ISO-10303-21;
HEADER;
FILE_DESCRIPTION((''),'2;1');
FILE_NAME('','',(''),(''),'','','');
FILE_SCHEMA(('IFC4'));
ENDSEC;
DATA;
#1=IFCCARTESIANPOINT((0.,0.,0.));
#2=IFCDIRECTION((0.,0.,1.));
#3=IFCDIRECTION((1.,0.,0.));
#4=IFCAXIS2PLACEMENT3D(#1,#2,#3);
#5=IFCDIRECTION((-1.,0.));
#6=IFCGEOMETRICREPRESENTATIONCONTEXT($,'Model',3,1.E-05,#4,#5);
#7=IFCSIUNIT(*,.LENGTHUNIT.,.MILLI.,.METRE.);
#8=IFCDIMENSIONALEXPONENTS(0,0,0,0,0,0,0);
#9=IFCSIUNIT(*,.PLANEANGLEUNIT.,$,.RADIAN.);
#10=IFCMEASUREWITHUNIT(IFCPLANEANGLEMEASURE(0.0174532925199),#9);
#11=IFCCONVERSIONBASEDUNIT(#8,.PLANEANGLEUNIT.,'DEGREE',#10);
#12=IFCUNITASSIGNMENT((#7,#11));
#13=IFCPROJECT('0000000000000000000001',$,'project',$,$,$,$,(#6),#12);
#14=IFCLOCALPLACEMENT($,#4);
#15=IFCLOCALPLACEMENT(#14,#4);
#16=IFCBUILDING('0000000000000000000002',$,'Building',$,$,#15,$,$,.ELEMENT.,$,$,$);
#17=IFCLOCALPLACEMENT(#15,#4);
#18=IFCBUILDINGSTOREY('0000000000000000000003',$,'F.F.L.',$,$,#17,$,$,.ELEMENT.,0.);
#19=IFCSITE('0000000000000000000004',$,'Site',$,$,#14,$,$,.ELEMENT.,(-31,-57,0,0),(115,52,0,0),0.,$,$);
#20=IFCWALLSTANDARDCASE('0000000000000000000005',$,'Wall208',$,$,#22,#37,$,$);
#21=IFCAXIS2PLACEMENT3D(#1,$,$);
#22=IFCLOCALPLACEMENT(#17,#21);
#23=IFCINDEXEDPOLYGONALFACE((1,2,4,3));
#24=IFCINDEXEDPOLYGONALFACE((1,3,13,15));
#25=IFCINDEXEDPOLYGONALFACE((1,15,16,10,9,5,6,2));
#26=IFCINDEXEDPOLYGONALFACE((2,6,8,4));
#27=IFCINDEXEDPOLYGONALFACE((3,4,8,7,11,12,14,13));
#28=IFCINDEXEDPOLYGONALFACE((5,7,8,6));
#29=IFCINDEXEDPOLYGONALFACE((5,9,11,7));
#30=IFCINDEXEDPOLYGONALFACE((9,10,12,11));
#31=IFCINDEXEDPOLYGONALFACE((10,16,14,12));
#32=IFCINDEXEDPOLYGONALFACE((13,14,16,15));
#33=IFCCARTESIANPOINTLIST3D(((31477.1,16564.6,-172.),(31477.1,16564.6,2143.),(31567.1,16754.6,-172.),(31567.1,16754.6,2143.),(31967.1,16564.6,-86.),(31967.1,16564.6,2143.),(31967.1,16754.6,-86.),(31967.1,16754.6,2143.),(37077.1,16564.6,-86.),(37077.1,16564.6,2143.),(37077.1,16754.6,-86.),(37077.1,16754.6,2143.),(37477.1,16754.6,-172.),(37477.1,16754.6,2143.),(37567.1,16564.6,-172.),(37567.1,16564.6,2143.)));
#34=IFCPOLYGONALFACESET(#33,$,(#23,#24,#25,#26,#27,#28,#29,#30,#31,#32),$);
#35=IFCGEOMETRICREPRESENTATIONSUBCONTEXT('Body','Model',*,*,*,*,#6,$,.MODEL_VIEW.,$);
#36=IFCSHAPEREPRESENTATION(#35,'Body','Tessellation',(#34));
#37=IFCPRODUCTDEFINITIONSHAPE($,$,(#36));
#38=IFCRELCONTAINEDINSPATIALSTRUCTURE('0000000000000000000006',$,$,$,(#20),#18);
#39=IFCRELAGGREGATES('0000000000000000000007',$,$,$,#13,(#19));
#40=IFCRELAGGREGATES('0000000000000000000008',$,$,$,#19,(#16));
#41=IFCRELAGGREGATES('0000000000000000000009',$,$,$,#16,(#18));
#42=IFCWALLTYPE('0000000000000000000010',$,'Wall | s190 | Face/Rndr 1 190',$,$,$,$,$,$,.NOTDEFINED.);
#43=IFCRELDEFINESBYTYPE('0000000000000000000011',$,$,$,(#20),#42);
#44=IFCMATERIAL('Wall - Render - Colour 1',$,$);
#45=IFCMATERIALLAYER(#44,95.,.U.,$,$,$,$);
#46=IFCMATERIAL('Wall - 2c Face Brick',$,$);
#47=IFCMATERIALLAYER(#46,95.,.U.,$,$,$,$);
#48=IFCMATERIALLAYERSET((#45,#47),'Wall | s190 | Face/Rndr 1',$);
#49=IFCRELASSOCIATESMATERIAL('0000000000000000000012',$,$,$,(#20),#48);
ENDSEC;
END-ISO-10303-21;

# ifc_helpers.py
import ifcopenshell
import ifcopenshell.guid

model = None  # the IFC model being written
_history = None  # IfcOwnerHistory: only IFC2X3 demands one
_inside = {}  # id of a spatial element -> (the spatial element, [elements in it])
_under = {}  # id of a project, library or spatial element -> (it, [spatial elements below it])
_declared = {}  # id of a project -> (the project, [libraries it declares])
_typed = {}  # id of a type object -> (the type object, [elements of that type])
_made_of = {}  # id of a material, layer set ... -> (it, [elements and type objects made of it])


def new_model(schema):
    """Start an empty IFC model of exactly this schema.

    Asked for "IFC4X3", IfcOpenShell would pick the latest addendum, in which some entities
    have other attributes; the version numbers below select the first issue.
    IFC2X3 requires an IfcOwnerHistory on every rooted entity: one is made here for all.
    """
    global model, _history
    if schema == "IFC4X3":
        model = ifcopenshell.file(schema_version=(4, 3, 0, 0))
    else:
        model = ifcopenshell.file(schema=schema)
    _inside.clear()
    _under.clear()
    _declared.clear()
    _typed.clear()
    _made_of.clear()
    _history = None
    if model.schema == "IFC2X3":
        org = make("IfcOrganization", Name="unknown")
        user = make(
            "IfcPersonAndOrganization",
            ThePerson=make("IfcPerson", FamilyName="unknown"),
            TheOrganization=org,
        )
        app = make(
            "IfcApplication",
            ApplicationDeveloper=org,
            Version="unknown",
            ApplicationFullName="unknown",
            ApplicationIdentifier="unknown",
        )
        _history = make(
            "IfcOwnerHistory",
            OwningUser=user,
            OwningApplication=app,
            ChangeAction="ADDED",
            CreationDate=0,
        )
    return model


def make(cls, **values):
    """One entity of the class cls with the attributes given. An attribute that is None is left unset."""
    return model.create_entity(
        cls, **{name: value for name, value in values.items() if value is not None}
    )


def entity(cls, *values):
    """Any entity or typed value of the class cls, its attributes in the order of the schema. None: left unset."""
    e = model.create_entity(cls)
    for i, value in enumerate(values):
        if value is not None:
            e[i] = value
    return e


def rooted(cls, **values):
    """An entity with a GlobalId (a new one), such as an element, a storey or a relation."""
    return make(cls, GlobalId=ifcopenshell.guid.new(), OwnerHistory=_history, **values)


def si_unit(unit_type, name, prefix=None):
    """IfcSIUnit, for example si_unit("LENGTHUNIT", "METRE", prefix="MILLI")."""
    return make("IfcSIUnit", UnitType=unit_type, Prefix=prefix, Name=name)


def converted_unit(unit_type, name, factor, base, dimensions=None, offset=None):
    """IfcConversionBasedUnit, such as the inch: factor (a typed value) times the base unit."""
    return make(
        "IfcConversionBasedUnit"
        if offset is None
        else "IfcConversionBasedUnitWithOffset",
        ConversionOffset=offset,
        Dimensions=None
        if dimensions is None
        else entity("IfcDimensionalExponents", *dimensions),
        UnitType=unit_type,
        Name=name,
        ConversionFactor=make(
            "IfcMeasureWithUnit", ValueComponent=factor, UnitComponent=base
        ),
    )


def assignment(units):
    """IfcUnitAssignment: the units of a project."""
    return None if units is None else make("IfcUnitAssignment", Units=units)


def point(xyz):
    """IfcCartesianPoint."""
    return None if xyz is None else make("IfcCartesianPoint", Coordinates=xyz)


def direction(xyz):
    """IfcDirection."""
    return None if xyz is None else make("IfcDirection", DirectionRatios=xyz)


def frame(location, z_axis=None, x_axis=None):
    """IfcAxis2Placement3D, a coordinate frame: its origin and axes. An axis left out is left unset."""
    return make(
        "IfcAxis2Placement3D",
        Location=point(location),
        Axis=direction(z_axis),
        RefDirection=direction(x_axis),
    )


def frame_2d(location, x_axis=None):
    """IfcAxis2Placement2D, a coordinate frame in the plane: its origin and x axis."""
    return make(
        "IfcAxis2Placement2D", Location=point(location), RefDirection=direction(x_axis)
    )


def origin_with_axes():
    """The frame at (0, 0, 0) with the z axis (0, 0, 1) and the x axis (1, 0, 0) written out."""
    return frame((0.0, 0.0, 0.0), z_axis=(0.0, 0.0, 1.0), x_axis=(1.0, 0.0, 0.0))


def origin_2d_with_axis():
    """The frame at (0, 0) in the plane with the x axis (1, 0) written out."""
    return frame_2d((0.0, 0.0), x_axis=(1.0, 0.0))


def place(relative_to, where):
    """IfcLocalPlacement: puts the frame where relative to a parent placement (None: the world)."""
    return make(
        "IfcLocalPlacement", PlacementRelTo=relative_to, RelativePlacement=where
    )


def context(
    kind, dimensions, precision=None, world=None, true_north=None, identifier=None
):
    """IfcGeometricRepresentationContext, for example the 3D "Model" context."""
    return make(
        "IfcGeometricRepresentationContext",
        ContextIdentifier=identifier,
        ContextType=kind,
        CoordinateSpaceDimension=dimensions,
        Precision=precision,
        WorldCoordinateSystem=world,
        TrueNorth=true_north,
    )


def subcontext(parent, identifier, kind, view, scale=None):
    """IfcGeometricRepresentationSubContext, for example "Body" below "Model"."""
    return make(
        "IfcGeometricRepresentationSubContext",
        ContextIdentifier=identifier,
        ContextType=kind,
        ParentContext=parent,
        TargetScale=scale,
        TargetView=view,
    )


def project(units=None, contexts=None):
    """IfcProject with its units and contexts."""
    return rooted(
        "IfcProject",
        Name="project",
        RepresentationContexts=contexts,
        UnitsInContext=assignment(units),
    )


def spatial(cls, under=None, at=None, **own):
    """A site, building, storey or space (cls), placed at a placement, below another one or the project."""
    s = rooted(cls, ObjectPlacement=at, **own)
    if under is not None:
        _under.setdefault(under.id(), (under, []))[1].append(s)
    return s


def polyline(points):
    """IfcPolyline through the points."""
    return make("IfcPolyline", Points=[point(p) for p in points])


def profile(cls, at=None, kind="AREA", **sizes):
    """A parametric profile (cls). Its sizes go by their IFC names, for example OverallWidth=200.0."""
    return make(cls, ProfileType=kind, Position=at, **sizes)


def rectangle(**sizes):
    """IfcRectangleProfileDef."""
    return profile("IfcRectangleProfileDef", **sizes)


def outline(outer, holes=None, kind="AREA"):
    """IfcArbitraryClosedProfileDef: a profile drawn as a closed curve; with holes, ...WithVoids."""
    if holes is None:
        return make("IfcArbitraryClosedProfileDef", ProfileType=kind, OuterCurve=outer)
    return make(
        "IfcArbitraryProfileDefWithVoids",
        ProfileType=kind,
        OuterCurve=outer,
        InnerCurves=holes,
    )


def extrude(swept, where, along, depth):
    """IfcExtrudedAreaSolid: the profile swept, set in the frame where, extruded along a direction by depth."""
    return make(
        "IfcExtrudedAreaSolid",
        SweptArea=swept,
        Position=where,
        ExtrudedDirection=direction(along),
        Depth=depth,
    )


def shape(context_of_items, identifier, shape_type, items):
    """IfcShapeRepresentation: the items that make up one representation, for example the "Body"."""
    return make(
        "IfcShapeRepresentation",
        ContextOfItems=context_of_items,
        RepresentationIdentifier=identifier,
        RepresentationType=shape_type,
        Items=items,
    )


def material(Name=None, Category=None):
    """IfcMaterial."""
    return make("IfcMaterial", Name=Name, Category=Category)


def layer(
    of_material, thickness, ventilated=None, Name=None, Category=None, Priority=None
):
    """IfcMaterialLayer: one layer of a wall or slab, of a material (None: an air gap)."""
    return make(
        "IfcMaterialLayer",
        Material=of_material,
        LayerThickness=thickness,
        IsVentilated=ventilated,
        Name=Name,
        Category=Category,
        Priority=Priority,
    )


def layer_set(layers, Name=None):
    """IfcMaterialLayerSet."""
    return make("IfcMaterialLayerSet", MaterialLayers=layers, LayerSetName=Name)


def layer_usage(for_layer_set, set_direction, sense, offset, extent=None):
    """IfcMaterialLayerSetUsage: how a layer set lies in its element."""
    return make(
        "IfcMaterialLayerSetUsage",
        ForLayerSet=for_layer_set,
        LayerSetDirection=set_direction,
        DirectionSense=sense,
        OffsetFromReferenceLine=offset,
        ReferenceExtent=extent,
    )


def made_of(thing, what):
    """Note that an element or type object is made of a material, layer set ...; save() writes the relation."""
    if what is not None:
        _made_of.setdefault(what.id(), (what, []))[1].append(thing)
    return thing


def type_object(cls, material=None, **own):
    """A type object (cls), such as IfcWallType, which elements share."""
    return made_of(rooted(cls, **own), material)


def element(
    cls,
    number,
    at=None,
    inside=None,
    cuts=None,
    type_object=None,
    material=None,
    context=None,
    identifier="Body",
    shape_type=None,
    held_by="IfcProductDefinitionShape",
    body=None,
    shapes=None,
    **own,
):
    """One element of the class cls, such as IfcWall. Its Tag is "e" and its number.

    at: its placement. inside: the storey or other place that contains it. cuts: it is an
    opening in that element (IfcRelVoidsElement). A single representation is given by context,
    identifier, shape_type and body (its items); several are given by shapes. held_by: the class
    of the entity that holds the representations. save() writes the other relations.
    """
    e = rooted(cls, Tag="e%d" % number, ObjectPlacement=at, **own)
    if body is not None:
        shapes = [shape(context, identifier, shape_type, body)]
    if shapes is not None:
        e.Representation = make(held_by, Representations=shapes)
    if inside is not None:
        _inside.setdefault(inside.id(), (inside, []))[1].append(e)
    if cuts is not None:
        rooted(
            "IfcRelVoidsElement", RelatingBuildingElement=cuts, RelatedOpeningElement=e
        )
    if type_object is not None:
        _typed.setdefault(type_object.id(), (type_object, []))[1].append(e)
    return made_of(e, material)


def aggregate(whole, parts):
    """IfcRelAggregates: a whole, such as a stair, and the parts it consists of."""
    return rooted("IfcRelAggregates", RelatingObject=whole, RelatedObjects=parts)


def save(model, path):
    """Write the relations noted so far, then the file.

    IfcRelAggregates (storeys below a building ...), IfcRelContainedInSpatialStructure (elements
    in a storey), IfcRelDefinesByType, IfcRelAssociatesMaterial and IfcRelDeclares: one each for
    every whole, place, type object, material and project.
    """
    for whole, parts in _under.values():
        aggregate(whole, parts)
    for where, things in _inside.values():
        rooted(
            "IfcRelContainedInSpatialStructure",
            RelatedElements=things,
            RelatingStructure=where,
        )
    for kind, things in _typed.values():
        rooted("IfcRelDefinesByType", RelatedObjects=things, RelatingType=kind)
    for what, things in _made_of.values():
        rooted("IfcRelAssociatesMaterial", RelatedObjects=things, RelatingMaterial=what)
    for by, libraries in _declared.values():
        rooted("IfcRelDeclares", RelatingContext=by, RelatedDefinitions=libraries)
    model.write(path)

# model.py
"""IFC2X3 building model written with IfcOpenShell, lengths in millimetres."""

from ifc_helpers import new_model, entity, si_unit, converted_unit, direction, frame, origin_with_axes, origin_2d_with_axis, place, context, subcontext, project, spatial, polyline, rectangle, outline, extrude, material, layer, layer_set, layer_usage, type_object, element, save


model = new_model("IFC2X3")

# Units and contexts
model_context = context("Model", 3, precision=1e-05, world=origin_with_axes(), true_north=direction((-1.0, 0.0)))
body_context = subcontext(model_context, "Body", "Model", "MODEL_VIEW")
ifc_project = project(units=[si_unit("LENGTHUNIT", "METRE", prefix="MILLI"), converted_unit("PLANEANGLEUNIT", "DEGREE", entity("IfcPlaneAngleMeasure", 0.0174532925199), si_unit("PLANEANGLEUNIT", "RADIAN"), dimensions=[0, 0, 0, 0, 0, 0, 0])], contexts=[model_context])

# Site, building, storey
site_placement = place(None, origin_with_axes())
site = spatial("IfcSite", under=ifc_project, at=site_placement, Name="Site", CompositionType="ELEMENT", RefLatitude=(-31, -57, 0, 0), RefLongitude=(115, 52, 0, 0), RefElevation=0.0)
building_placement = place(site_placement, origin_with_axes())
building = spatial("IfcBuilding", under=site, at=building_placement, Name="Building", CompositionType="ELEMENT")
storey_placement = place(building_placement, origin_with_axes())
storey = spatial("IfcBuildingStorey", under=building, at=storey_placement, Name="F.F.L.", CompositionType="ELEMENT", Elevation=0.0)

# Shared definitions
ifc_material_1 = material(Name="Wall - 2c Face Brick")

# Shared definitions
ifc_material_2 = material(Name="Wall - Render - Colour 1")

# Wall, opening
ifc_layer_1 = layer(ifc_material_2, 95.0, ventilated="UNKNOWN")
ifc_layer_2 = layer(ifc_material_1, 95.0, ventilated="UNKNOWN")
ifc_layer_set_1 = layer_set([ifc_layer_1, ifc_layer_2], Name="Wall | s190 | Face/Rndr 1")
ifc_layer_usage_1 = layer_usage(ifc_layer_set_1, "AXIS2", "NEGATIVE", 0.0)
wall_type_1 = type_object("IfcWallType", Name="Wall | s190 | Face/Rndr 1 190", PredefinedType="NOTDEFINED")
wall_1_placement = place(storey_placement, frame((37567.1, 16564.6, -172.0), z_axis=(0.0, 0.0, 1.0), x_axis=(-1.0, 0.0, 0.0)))
wall_1 = element("IfcWallStandardCase", 1, at=wall_1_placement, inside=storey, type_object=wall_type_1, material=ifc_layer_usage_1, Name="Wall208", context=body_context, shape_type="SweptSolid", body=[
    extrude(outline(polyline([(90.0, -190.0), (6000.0, -190.0), (6090.0, 0.0), (0.0, 0.0), (90.0, -190.0)])), origin_with_axes(), (0.0, 0.0, 1.0), 2315.0),
])
opening_1_placement = place(wall_1_placement, frame((3045.0, 0.0, 86.0), z_axis=(0.0, 0.0, 1.0), x_axis=(1.0, 0.0, 0.0)))
element("IfcOpeningElement", 2, at=opening_1_placement, cuts=wall_1, context=body_context, shape_type="SweptSolid", body=[
    extrude(rectangle(XDim=5110.0, YDim=2229.0, at=origin_2d_with_axis()), frame((0.0, -190.0, 1114.5), z_axis=(0.0, -1.0, 0.0), x_axis=(1.0, 0.0, 0.0)), (0.0, 0.0, -1.0), 570.0),
])

save(model, "model.ifc")
